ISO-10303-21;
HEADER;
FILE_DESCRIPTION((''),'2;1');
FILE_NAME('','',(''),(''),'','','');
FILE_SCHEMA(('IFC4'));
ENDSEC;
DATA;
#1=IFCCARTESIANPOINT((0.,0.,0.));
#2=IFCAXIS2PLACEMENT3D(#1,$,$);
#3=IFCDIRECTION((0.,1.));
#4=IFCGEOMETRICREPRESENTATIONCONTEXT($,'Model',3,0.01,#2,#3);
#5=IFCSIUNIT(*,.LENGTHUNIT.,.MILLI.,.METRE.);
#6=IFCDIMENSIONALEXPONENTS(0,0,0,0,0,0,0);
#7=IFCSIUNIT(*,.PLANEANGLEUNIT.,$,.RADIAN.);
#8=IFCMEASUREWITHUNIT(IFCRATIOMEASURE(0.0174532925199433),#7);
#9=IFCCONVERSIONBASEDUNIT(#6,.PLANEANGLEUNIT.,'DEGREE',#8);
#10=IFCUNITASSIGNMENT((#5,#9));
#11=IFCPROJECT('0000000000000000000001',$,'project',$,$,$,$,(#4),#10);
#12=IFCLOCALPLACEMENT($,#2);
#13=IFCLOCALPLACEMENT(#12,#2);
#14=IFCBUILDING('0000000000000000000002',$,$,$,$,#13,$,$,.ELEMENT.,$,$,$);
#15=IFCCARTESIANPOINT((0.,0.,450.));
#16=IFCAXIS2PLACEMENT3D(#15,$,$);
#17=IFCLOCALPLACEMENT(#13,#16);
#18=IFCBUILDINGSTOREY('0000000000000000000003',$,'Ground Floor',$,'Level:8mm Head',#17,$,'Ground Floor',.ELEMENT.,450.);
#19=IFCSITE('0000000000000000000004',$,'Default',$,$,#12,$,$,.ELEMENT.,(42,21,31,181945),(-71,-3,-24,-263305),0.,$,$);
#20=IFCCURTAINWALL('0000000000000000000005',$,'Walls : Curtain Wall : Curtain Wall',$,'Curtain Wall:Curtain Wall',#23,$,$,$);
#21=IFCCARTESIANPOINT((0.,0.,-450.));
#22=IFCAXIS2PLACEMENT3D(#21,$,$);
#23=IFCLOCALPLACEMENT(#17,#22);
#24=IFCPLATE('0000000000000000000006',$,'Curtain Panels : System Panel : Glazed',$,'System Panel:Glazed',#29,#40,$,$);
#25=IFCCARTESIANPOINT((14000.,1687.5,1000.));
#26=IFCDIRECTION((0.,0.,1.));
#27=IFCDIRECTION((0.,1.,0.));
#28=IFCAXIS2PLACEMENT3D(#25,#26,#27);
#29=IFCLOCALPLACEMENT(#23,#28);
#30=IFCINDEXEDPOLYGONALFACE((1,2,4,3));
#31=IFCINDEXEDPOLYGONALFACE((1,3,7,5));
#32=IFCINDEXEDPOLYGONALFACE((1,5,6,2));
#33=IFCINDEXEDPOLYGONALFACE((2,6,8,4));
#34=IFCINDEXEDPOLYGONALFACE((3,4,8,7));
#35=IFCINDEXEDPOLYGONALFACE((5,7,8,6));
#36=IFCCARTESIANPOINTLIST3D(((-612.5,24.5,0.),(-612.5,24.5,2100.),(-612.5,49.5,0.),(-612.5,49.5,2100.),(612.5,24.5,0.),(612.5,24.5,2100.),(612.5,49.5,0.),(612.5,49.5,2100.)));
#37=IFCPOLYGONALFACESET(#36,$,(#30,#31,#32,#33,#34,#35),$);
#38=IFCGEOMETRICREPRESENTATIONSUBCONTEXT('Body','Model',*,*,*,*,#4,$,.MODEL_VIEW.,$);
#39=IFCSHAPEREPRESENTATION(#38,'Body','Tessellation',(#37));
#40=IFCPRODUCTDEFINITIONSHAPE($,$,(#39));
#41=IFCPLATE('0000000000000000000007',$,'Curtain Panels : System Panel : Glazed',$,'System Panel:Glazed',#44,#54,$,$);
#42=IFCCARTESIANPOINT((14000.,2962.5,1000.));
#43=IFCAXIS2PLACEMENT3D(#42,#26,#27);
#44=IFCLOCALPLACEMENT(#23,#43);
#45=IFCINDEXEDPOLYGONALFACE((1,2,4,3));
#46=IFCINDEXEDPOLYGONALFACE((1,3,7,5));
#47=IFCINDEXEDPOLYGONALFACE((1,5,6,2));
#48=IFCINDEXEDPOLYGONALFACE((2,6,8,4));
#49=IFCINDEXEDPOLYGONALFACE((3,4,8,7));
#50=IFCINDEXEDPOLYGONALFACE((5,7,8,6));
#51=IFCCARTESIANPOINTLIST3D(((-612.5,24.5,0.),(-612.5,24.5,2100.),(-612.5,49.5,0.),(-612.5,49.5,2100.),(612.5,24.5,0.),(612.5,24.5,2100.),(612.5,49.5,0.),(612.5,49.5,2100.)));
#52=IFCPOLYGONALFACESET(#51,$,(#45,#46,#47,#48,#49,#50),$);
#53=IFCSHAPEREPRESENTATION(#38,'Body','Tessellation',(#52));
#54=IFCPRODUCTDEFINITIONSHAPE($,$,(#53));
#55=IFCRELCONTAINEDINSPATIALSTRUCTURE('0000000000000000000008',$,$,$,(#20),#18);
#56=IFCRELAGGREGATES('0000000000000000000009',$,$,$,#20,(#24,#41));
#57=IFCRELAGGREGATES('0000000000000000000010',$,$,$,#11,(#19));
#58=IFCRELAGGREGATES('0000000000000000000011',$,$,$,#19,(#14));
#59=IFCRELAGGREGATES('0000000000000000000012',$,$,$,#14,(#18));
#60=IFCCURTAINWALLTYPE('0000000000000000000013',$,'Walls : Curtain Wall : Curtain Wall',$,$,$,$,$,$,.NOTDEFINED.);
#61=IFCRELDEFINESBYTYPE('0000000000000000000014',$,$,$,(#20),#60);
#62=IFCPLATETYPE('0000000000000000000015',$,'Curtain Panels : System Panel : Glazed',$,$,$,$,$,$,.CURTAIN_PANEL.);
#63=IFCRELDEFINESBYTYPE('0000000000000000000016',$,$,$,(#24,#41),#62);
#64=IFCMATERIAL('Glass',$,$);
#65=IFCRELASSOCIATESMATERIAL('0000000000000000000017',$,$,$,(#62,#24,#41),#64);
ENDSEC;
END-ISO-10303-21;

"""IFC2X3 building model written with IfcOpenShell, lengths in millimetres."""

from ifc_helpers import new_model, entity, si_unit, converted_unit, direction, frame, origin, origin_2d_with_axis, place, context, subcontext, project, spatial, rectangle, extrude, source, transform, mapped, material, type_object, type_shapes, element, aggregate, save


model = new_model("IFC2X3")

# Units and contexts
model_context = context("Model", 3, precision=0.01, world=origin(), true_north=direction((0.0, 1.0)))
body_context = subcontext(model_context, "Body", "Model", "MODEL_VIEW")
ifc_project = project(units=[si_unit("LENGTHUNIT", "METRE", prefix="MILLI"), converted_unit("PLANEANGLEUNIT", "DEGREE", entity("IfcRatioMeasure", 0.0174532925199433), si_unit("PLANEANGLEUNIT", "RADIAN"), dimensions=[0, 0, 0, 0, 0, 0, 0])], contexts=[model_context])

# Site, building, storey
site_placement = place(None, origin())
site = spatial("IfcSite", under=ifc_project, at=site_placement, Name="Default", CompositionType="ELEMENT", RefLatitude=(42, 21, 31, 181945), RefLongitude=(-71, -3, -24, -263305), RefElevation=0.0)
building_placement = place(site_placement, origin())
building = spatial("IfcBuilding", under=site, at=building_placement, CompositionType="ELEMENT")
storey_placement = place(building_placement, frame((0.0, 0.0, 450.0)))
storey = spatial("IfcBuildingStorey", under=building, at=storey_placement, Name="Ground Floor", ObjectType="Level:8mm Head", LongName="Ground Floor", CompositionType="ELEMENT", Elevation=450.0)

# Curtain wall, plates
curtain_wall_type = type_object("IfcCurtainWallType", Name="Walls : Curtain Wall : Curtain Wall", PredefinedType="NOTDEFINED")
curtain_wall_placement = place(storey_placement, frame((0.0, 0.0, -450.0)))
curtain_wall = element("IfcCurtainWall", 1, at=curtain_wall_placement, inside=storey, type_object=curtain_wall_type, Name="Walls : Curtain Wall : Curtain Wall", ObjectType="Curtain Wall:Curtain Wall")
ifc_material_1 = material(Name="Glass")
plate_type = type_object("IfcPlateType", Name="Curtain Panels : System Panel : Glazed", PredefinedType="CURTAIN_PANEL", material=ifc_material_1)
shared_shape_1 = source(origin(), body_context, "Body", "SweptSolid", [
    extrude(rectangle(XDim=25.0, YDim=1225.0, at=origin_2d_with_axis()), frame((0.0, 37.0, 0.0), z_axis=(0.0, 0.0, 1.0), x_axis=(0.0, 1.0, 0.0)), (0.0, 0.0, 1.0), 2100.0),
])
type_shapes(plate_type, [shared_shape_1])
plate_1_placement = place(curtain_wall_placement, frame((14000.0, 1687.5, 1000.0), z_axis=(0.0, 0.0, 1.0), x_axis=(0.0, 1.0, 0.0)))
plate_1 = element("IfcPlate", 2, at=plate_1_placement, type_object=plate_type, material=ifc_material_1, Name="Curtain Panels : System Panel : Glazed", ObjectType="System Panel:Glazed", context=body_context, shape_type="MappedRepresentation", body=[
    mapped(shared_shape_1, transform((0.0, 0.0, 0.0), scale=1.0)),
])
plate_2_placement = place(curtain_wall_placement, frame((14000.0, 2962.5, 1000.0), z_axis=(0.0, 0.0, 1.0), x_axis=(0.0, 1.0, 0.0)))
plate_2 = element("IfcPlate", 3, at=plate_2_placement, type_object=plate_type, material=ifc_material_1, Name="Curtain Panels : System Panel : Glazed", ObjectType="System Panel:Glazed", context=body_context, shape_type="MappedRepresentation", body=[
    mapped(shared_shape_1, transform((0.0, 0.0, 0.0), scale=1.0)),
])
aggregate(curtain_wall, [plate_1, plate_2])

save(model, "model.ifc")
